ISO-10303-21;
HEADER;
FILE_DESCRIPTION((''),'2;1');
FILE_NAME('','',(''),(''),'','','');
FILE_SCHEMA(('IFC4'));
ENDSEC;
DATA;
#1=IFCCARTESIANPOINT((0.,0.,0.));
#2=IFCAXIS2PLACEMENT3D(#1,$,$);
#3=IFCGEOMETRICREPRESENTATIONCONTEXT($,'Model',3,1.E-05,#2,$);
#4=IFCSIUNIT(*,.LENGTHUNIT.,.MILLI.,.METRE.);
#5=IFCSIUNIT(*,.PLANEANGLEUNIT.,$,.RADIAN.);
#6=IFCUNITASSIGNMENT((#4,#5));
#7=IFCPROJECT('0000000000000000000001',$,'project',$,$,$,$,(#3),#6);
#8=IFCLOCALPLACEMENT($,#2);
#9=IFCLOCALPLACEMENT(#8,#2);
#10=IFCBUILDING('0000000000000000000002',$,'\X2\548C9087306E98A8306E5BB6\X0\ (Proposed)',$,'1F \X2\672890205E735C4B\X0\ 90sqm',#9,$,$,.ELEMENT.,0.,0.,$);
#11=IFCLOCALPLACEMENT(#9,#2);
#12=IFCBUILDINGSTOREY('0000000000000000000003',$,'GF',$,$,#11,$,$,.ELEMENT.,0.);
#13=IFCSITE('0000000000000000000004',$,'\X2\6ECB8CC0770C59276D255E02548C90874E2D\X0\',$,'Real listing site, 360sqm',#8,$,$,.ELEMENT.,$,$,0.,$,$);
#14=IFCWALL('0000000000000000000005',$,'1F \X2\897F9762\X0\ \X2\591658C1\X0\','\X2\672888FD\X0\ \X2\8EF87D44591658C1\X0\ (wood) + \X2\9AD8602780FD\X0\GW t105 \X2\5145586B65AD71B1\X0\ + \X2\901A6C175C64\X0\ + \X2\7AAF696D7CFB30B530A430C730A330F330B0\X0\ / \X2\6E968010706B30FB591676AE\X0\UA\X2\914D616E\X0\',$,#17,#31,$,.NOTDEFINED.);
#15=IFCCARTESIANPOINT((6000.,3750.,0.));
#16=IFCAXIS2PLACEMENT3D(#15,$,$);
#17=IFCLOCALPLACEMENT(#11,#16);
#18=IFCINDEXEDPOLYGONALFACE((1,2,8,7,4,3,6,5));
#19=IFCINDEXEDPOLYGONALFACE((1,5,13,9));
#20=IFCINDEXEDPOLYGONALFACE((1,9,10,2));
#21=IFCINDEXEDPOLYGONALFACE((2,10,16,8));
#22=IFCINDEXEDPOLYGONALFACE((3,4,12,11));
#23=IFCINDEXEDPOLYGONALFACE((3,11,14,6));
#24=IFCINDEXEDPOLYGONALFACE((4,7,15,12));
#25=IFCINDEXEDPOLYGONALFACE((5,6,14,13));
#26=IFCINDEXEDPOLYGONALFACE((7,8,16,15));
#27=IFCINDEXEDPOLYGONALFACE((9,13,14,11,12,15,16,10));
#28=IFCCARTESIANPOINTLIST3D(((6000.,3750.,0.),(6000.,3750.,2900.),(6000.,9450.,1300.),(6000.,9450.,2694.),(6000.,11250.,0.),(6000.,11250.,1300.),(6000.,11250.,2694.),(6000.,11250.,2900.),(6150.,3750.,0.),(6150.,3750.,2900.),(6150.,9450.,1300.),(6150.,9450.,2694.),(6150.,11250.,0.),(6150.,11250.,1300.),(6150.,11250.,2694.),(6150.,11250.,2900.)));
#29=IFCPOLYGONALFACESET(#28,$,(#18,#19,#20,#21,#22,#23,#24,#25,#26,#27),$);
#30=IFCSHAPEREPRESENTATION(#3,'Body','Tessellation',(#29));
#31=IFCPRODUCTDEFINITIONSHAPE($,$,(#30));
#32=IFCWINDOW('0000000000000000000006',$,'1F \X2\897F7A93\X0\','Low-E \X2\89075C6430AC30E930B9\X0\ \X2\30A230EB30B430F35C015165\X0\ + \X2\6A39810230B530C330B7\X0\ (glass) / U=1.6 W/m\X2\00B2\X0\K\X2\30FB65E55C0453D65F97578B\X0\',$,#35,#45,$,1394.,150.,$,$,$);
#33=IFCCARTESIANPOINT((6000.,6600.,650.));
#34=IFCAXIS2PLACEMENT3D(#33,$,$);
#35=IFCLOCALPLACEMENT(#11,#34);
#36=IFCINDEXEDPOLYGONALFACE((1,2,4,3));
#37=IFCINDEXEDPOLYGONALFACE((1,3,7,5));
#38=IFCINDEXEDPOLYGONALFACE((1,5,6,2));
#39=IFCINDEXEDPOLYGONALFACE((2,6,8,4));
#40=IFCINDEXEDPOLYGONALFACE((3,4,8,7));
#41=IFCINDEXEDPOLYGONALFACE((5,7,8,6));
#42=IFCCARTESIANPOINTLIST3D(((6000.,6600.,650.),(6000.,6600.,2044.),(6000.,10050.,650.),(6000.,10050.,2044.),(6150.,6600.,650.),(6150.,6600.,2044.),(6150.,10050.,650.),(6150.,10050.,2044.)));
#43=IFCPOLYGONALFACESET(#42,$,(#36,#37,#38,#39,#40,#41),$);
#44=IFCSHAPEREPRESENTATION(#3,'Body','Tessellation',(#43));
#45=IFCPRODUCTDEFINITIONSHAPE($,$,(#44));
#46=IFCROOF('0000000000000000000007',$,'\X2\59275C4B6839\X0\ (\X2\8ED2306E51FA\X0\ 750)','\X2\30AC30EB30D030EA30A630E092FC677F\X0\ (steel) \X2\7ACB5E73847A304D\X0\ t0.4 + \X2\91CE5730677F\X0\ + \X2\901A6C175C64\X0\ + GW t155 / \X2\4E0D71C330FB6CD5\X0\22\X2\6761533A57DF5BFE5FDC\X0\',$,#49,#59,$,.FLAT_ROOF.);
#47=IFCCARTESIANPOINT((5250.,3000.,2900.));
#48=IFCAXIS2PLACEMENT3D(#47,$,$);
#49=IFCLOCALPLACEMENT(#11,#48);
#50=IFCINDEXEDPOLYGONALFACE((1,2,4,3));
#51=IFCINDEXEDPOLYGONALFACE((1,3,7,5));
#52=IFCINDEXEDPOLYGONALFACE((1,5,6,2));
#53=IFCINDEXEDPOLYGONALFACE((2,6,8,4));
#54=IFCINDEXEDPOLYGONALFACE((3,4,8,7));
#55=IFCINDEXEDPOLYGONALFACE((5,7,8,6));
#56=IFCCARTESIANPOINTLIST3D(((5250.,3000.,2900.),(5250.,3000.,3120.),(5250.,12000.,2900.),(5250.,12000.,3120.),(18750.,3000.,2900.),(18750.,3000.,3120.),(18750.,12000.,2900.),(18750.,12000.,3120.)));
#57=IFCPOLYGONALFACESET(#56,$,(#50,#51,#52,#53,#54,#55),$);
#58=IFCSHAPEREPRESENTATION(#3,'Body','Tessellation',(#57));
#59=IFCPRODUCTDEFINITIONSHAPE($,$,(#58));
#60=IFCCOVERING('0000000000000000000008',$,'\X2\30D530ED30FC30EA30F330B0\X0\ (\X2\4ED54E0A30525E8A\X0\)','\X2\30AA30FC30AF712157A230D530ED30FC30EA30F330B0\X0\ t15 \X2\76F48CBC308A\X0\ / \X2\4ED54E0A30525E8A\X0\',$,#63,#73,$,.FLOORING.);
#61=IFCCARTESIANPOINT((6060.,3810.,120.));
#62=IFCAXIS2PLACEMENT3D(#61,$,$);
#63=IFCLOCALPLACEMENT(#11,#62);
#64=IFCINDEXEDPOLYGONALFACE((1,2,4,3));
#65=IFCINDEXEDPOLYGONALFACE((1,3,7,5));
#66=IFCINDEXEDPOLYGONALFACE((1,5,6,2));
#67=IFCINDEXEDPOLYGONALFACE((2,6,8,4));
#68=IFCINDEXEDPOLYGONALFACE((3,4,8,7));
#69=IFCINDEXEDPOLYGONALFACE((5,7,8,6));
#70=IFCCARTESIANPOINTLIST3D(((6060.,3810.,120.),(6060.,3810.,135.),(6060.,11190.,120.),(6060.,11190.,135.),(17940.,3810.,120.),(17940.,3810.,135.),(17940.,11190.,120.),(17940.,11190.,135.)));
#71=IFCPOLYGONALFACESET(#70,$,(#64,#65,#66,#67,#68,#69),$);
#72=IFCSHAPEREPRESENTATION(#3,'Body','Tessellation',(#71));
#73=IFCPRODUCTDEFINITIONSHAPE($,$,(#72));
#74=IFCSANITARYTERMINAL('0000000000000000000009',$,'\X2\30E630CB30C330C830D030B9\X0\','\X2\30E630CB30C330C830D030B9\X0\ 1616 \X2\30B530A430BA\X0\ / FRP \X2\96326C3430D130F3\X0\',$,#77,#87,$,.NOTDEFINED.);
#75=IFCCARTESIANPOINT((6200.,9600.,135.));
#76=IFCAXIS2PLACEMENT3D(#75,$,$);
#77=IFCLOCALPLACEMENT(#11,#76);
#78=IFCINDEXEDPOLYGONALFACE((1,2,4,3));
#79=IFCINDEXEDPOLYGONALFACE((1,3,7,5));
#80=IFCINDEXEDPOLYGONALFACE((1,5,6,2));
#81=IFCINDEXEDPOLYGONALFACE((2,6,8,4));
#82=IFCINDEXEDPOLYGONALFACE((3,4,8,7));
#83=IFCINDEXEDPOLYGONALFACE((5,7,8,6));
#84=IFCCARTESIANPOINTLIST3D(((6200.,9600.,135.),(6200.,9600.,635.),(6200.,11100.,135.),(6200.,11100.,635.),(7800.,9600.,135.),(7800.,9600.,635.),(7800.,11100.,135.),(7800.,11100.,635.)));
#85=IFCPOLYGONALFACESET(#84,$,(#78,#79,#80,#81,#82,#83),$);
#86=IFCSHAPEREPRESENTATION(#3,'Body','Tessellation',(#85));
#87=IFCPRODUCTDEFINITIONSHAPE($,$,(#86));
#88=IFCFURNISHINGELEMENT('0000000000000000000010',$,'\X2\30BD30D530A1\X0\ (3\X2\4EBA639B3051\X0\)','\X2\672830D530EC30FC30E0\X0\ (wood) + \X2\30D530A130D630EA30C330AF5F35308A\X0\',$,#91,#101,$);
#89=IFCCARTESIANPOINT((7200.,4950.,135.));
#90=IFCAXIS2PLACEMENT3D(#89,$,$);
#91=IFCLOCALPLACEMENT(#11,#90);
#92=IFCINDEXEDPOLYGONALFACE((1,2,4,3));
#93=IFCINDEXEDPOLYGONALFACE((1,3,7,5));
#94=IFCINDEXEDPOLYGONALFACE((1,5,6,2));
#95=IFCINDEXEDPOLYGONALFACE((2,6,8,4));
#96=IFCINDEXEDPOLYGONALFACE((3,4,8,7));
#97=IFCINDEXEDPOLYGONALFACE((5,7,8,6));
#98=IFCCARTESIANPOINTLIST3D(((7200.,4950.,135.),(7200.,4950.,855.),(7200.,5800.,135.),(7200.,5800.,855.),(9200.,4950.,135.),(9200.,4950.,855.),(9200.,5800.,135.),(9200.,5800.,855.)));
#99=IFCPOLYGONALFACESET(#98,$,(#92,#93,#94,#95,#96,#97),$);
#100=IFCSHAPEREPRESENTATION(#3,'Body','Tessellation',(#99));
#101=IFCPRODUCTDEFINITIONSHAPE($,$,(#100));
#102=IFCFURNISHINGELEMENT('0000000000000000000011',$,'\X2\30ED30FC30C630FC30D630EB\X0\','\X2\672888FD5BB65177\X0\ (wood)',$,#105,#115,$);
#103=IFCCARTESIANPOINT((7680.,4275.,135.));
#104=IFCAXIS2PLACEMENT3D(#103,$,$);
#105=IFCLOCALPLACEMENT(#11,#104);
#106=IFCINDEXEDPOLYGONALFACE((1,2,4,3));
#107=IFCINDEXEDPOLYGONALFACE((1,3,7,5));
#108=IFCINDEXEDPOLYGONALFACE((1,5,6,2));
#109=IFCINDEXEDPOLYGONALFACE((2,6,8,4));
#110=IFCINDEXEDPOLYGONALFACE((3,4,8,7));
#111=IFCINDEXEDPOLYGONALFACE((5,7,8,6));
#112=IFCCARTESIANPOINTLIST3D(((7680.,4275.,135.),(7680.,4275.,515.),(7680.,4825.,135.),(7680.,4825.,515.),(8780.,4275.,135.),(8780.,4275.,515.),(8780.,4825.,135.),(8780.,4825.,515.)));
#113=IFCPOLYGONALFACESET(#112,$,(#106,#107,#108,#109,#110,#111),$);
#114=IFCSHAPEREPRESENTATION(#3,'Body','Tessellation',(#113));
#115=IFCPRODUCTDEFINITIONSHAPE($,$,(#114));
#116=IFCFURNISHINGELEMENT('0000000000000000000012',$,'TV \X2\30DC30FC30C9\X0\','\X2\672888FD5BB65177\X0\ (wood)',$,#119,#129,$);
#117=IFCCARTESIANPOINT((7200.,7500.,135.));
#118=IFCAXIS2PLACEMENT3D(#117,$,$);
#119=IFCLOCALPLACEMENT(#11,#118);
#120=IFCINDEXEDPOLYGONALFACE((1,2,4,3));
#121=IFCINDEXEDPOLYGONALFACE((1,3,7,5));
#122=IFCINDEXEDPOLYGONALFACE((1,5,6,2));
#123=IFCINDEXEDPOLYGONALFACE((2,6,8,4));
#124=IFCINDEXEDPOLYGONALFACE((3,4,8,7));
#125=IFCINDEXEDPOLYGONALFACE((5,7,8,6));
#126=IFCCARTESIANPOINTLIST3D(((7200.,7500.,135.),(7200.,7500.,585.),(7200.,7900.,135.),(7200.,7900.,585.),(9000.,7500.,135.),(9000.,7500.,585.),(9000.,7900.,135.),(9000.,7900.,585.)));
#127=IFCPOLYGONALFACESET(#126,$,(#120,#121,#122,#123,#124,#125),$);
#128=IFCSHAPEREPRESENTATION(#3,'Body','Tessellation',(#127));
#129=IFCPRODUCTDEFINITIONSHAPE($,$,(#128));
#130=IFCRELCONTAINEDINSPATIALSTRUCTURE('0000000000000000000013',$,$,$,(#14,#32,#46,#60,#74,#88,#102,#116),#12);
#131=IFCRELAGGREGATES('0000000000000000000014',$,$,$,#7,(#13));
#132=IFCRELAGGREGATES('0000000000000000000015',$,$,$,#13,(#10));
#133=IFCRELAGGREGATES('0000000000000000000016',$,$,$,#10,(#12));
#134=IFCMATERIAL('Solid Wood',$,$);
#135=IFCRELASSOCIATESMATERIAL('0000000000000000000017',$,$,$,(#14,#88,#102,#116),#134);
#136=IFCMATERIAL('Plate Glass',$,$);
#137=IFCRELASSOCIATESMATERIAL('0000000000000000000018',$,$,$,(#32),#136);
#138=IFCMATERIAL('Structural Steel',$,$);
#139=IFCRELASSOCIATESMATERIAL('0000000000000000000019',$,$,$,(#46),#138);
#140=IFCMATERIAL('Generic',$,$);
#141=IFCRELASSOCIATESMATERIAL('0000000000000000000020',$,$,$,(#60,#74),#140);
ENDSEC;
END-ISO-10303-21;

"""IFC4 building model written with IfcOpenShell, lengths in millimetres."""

from ifc_helpers import new_model, si_unit, frame, frame_2d, origin, place, context, project, spatial, rectangle, extrude, material, element, fill, save


model = new_model("IFC4")

# Units and contexts
model_context = context("Model", 3, precision=1e-05, world=origin())
ifc_project = project(units=[si_unit("LENGTHUNIT", "METRE", prefix="MILLI"), si_unit("PLANEANGLEUNIT", "RADIAN")], contexts=[model_context])

# Site, building, storey
site_placement = place(None, origin())
site = spatial("IfcSite", under=ifc_project, at=site_placement, Name="滋賀県大津市和邇中", ObjectType="Real listing site, 360sqm", CompositionType="ELEMENT", RefElevation=0.0)
building_placement = place(site_placement, origin())
building = spatial("IfcBuilding", under=site, at=building_placement, Name="和邇の風の家 (Proposed)", ObjectType="1F 木造平屋 90sqm", CompositionType="ELEMENT", ElevationOfRefHeight=0.0, ElevationOfTerrain=0.0)
storey_placement = place(building_placement, origin())
storey = spatial("IfcBuildingStorey", under=building, at=storey_placement, Name="GF", CompositionType="ELEMENT", Elevation=0.0)

# Shared definitions
ifc_material_1 = material(Name="Solid Wood")

# Shared definitions
ifc_material_2 = material(Name="Plate Glass")

# Wall, opening, window
wall_1_placement = place(storey_placement, frame((6000.0, 3750.0, 0.0)))
wall_1 = element("IfcWall", 1, at=wall_1_placement, inside=storey, material=ifc_material_1, Name="1F 西面 外壁", Description="木製 軸組外壁 (wood) + 高性能GW t105 充填断熱 + 通気層 + 窯業系サイディング / 準耐火・外皮UA配慮", PredefinedType="NOTDEFINED", context=model_context, shape_type="SweptSolid", body=[
    extrude(rectangle(XDim=150.0, YDim=7500.0, at=frame_2d((75.0, 3750.0))), frame((6000.0, 3750.0, 0.0)), (0.0, 0.0, 1.0), 2900.0),
])
opening_1_placement = place(storey_placement, frame((6000.0, 6600.0, 650.0)))
opening_1 = element("IfcOpeningElement", 2, at=opening_1_placement, cuts=wall_1, PredefinedType="NOTDEFINED", context=model_context, shape_type="SweptSolid", body=[
    extrude(rectangle(XDim=150.0, YDim=3450.0, at=frame_2d((75.0, 1725.0))), frame((6000.0, 6600.0, 650.0)), (0.0, 0.0, 1.0), 1394.0),
])
window_1_placement = place(storey_placement, frame((6000.0, 6600.0, 650.0)))
window_1 = element("IfcWindow", 3, at=window_1_placement, inside=storey, material=ifc_material_2, Name="1F 西窓", Description="Low-E 複層ガラス アルゴン封入 + 樹脂サッシ (glass) / U=1.6 W/m²K・日射取得型", OverallHeight=1394.0, OverallWidth=150.0, context=model_context, shape_type="SweptSolid", body=[
    extrude(rectangle(XDim=150.0, YDim=3450.0, at=frame_2d((75.0, 1725.0))), frame((6000.0, 6600.0, 650.0)), (0.0, 0.0, 1.0), 1394.0),
])
fill(opening_1, window_1)

# Roof
ifc_material_3 = material(Name="Structural Steel")
roof_placement = place(storey_placement, frame((5250.0, 3000.0, 2900.0)))
element("IfcRoof", 4, at=roof_placement, inside=storey, material=ifc_material_3, Name="大屋根 (軒の出 750)", Description="ガルバリウム鋼板 (steel) 立平葺き t0.4 + 野地板 + 通気層 + GW t155 / 不燃・法22条区域対応", PredefinedType="FLAT_ROOF", context=model_context, shape_type="SweptSolid", body=[
    extrude(rectangle(XDim=13500.0, YDim=9000.0, at=frame_2d((6750.0, 4500.0))), frame((5250.0, 3000.0, 2900.0)), (0.0, 0.0, 1.0), 220.0),
])

# Covering
ifc_material_4 = material(Name="Generic")
covering_placement = place(storey_placement, frame((6060.0, 3810.0, 120.0)))
element("IfcCovering", 5, at=covering_placement, inside=storey, material=ifc_material_4, Name="フローリング (仕上げ床)", Description="オーク無垢フローリング t15 直貼り / 仕上げ床", PredefinedType="FLOORING", context=model_context, shape_type="SweptSolid", body=[
    extrude(rectangle(XDim=11880.0, YDim=7380.0, at=frame_2d((5940.0, 3690.0))), frame((6060.0, 3810.0, 120.0)), (0.0, 0.0, 1.0), 15.0),
])

# Sanitary terminal
sanitary_terminal_placement = place(storey_placement, frame((6200.0, 9600.0, 135.0)))
element("IfcSanitaryTerminal", 6, at=sanitary_terminal_placement, inside=storey, material=ifc_material_4, Name="ユニットバス", Description="ユニットバス 1616 サイズ / FRP 防水パン", PredefinedType="NOTDEFINED", context=model_context, shape_type="SweptSolid", body=[
    extrude(rectangle(XDim=1600.0, YDim=1500.0, at=frame_2d((800.0, 750.0))), frame((6200.0, 9600.0, 135.0)), (0.0, 0.0, 1.0), 500.0),
])

# Furnishing elements
furnishing_1_placement = place(storey_placement, frame((7200.0, 4950.0, 135.0)))
element("IfcFurnishingElement", 7, at=furnishing_1_placement, inside=storey, material=ifc_material_1, Name="ソファ (3人掛け)", Description="木フレーム (wood) + ファブリック張り", context=model_context, shape_type="SweptSolid", body=[
    extrude(rectangle(XDim=2000.0, YDim=850.0, at=frame_2d((1000.0, 425.0))), frame((7200.0, 4950.0, 135.0)), (0.0, 0.0, 1.0), 720.0),
])
furnishing_2_placement = place(storey_placement, frame((7680.0, 4275.0, 135.0)))
element("IfcFurnishingElement", 8, at=furnishing_2_placement, inside=storey, material=ifc_material_1, Name="ローテーブル", Description="木製家具 (wood)", context=model_context, shape_type="SweptSolid", body=[
    extrude(rectangle(XDim=1100.0, YDim=550.0, at=frame_2d((550.0, 275.0))), frame((7680.0, 4275.0, 135.0)), (0.0, 0.0, 1.0), 380.0),
])
furnishing_3_placement = place(storey_placement, frame((7200.0, 7500.0, 135.0)))
element("IfcFurnishingElement", 9, at=furnishing_3_placement, inside=storey, material=ifc_material_1, Name="TV ボード", Description="木製家具 (wood)", context=model_context, shape_type="SweptSolid", body=[
    extrude(rectangle(XDim=1800.0, YDim=400.0, at=frame_2d((900.0, 200.0))), frame((7200.0, 7500.0, 135.0)), (0.0, 0.0, 1.0), 450.0),
])

save(model, "model.ifc")
